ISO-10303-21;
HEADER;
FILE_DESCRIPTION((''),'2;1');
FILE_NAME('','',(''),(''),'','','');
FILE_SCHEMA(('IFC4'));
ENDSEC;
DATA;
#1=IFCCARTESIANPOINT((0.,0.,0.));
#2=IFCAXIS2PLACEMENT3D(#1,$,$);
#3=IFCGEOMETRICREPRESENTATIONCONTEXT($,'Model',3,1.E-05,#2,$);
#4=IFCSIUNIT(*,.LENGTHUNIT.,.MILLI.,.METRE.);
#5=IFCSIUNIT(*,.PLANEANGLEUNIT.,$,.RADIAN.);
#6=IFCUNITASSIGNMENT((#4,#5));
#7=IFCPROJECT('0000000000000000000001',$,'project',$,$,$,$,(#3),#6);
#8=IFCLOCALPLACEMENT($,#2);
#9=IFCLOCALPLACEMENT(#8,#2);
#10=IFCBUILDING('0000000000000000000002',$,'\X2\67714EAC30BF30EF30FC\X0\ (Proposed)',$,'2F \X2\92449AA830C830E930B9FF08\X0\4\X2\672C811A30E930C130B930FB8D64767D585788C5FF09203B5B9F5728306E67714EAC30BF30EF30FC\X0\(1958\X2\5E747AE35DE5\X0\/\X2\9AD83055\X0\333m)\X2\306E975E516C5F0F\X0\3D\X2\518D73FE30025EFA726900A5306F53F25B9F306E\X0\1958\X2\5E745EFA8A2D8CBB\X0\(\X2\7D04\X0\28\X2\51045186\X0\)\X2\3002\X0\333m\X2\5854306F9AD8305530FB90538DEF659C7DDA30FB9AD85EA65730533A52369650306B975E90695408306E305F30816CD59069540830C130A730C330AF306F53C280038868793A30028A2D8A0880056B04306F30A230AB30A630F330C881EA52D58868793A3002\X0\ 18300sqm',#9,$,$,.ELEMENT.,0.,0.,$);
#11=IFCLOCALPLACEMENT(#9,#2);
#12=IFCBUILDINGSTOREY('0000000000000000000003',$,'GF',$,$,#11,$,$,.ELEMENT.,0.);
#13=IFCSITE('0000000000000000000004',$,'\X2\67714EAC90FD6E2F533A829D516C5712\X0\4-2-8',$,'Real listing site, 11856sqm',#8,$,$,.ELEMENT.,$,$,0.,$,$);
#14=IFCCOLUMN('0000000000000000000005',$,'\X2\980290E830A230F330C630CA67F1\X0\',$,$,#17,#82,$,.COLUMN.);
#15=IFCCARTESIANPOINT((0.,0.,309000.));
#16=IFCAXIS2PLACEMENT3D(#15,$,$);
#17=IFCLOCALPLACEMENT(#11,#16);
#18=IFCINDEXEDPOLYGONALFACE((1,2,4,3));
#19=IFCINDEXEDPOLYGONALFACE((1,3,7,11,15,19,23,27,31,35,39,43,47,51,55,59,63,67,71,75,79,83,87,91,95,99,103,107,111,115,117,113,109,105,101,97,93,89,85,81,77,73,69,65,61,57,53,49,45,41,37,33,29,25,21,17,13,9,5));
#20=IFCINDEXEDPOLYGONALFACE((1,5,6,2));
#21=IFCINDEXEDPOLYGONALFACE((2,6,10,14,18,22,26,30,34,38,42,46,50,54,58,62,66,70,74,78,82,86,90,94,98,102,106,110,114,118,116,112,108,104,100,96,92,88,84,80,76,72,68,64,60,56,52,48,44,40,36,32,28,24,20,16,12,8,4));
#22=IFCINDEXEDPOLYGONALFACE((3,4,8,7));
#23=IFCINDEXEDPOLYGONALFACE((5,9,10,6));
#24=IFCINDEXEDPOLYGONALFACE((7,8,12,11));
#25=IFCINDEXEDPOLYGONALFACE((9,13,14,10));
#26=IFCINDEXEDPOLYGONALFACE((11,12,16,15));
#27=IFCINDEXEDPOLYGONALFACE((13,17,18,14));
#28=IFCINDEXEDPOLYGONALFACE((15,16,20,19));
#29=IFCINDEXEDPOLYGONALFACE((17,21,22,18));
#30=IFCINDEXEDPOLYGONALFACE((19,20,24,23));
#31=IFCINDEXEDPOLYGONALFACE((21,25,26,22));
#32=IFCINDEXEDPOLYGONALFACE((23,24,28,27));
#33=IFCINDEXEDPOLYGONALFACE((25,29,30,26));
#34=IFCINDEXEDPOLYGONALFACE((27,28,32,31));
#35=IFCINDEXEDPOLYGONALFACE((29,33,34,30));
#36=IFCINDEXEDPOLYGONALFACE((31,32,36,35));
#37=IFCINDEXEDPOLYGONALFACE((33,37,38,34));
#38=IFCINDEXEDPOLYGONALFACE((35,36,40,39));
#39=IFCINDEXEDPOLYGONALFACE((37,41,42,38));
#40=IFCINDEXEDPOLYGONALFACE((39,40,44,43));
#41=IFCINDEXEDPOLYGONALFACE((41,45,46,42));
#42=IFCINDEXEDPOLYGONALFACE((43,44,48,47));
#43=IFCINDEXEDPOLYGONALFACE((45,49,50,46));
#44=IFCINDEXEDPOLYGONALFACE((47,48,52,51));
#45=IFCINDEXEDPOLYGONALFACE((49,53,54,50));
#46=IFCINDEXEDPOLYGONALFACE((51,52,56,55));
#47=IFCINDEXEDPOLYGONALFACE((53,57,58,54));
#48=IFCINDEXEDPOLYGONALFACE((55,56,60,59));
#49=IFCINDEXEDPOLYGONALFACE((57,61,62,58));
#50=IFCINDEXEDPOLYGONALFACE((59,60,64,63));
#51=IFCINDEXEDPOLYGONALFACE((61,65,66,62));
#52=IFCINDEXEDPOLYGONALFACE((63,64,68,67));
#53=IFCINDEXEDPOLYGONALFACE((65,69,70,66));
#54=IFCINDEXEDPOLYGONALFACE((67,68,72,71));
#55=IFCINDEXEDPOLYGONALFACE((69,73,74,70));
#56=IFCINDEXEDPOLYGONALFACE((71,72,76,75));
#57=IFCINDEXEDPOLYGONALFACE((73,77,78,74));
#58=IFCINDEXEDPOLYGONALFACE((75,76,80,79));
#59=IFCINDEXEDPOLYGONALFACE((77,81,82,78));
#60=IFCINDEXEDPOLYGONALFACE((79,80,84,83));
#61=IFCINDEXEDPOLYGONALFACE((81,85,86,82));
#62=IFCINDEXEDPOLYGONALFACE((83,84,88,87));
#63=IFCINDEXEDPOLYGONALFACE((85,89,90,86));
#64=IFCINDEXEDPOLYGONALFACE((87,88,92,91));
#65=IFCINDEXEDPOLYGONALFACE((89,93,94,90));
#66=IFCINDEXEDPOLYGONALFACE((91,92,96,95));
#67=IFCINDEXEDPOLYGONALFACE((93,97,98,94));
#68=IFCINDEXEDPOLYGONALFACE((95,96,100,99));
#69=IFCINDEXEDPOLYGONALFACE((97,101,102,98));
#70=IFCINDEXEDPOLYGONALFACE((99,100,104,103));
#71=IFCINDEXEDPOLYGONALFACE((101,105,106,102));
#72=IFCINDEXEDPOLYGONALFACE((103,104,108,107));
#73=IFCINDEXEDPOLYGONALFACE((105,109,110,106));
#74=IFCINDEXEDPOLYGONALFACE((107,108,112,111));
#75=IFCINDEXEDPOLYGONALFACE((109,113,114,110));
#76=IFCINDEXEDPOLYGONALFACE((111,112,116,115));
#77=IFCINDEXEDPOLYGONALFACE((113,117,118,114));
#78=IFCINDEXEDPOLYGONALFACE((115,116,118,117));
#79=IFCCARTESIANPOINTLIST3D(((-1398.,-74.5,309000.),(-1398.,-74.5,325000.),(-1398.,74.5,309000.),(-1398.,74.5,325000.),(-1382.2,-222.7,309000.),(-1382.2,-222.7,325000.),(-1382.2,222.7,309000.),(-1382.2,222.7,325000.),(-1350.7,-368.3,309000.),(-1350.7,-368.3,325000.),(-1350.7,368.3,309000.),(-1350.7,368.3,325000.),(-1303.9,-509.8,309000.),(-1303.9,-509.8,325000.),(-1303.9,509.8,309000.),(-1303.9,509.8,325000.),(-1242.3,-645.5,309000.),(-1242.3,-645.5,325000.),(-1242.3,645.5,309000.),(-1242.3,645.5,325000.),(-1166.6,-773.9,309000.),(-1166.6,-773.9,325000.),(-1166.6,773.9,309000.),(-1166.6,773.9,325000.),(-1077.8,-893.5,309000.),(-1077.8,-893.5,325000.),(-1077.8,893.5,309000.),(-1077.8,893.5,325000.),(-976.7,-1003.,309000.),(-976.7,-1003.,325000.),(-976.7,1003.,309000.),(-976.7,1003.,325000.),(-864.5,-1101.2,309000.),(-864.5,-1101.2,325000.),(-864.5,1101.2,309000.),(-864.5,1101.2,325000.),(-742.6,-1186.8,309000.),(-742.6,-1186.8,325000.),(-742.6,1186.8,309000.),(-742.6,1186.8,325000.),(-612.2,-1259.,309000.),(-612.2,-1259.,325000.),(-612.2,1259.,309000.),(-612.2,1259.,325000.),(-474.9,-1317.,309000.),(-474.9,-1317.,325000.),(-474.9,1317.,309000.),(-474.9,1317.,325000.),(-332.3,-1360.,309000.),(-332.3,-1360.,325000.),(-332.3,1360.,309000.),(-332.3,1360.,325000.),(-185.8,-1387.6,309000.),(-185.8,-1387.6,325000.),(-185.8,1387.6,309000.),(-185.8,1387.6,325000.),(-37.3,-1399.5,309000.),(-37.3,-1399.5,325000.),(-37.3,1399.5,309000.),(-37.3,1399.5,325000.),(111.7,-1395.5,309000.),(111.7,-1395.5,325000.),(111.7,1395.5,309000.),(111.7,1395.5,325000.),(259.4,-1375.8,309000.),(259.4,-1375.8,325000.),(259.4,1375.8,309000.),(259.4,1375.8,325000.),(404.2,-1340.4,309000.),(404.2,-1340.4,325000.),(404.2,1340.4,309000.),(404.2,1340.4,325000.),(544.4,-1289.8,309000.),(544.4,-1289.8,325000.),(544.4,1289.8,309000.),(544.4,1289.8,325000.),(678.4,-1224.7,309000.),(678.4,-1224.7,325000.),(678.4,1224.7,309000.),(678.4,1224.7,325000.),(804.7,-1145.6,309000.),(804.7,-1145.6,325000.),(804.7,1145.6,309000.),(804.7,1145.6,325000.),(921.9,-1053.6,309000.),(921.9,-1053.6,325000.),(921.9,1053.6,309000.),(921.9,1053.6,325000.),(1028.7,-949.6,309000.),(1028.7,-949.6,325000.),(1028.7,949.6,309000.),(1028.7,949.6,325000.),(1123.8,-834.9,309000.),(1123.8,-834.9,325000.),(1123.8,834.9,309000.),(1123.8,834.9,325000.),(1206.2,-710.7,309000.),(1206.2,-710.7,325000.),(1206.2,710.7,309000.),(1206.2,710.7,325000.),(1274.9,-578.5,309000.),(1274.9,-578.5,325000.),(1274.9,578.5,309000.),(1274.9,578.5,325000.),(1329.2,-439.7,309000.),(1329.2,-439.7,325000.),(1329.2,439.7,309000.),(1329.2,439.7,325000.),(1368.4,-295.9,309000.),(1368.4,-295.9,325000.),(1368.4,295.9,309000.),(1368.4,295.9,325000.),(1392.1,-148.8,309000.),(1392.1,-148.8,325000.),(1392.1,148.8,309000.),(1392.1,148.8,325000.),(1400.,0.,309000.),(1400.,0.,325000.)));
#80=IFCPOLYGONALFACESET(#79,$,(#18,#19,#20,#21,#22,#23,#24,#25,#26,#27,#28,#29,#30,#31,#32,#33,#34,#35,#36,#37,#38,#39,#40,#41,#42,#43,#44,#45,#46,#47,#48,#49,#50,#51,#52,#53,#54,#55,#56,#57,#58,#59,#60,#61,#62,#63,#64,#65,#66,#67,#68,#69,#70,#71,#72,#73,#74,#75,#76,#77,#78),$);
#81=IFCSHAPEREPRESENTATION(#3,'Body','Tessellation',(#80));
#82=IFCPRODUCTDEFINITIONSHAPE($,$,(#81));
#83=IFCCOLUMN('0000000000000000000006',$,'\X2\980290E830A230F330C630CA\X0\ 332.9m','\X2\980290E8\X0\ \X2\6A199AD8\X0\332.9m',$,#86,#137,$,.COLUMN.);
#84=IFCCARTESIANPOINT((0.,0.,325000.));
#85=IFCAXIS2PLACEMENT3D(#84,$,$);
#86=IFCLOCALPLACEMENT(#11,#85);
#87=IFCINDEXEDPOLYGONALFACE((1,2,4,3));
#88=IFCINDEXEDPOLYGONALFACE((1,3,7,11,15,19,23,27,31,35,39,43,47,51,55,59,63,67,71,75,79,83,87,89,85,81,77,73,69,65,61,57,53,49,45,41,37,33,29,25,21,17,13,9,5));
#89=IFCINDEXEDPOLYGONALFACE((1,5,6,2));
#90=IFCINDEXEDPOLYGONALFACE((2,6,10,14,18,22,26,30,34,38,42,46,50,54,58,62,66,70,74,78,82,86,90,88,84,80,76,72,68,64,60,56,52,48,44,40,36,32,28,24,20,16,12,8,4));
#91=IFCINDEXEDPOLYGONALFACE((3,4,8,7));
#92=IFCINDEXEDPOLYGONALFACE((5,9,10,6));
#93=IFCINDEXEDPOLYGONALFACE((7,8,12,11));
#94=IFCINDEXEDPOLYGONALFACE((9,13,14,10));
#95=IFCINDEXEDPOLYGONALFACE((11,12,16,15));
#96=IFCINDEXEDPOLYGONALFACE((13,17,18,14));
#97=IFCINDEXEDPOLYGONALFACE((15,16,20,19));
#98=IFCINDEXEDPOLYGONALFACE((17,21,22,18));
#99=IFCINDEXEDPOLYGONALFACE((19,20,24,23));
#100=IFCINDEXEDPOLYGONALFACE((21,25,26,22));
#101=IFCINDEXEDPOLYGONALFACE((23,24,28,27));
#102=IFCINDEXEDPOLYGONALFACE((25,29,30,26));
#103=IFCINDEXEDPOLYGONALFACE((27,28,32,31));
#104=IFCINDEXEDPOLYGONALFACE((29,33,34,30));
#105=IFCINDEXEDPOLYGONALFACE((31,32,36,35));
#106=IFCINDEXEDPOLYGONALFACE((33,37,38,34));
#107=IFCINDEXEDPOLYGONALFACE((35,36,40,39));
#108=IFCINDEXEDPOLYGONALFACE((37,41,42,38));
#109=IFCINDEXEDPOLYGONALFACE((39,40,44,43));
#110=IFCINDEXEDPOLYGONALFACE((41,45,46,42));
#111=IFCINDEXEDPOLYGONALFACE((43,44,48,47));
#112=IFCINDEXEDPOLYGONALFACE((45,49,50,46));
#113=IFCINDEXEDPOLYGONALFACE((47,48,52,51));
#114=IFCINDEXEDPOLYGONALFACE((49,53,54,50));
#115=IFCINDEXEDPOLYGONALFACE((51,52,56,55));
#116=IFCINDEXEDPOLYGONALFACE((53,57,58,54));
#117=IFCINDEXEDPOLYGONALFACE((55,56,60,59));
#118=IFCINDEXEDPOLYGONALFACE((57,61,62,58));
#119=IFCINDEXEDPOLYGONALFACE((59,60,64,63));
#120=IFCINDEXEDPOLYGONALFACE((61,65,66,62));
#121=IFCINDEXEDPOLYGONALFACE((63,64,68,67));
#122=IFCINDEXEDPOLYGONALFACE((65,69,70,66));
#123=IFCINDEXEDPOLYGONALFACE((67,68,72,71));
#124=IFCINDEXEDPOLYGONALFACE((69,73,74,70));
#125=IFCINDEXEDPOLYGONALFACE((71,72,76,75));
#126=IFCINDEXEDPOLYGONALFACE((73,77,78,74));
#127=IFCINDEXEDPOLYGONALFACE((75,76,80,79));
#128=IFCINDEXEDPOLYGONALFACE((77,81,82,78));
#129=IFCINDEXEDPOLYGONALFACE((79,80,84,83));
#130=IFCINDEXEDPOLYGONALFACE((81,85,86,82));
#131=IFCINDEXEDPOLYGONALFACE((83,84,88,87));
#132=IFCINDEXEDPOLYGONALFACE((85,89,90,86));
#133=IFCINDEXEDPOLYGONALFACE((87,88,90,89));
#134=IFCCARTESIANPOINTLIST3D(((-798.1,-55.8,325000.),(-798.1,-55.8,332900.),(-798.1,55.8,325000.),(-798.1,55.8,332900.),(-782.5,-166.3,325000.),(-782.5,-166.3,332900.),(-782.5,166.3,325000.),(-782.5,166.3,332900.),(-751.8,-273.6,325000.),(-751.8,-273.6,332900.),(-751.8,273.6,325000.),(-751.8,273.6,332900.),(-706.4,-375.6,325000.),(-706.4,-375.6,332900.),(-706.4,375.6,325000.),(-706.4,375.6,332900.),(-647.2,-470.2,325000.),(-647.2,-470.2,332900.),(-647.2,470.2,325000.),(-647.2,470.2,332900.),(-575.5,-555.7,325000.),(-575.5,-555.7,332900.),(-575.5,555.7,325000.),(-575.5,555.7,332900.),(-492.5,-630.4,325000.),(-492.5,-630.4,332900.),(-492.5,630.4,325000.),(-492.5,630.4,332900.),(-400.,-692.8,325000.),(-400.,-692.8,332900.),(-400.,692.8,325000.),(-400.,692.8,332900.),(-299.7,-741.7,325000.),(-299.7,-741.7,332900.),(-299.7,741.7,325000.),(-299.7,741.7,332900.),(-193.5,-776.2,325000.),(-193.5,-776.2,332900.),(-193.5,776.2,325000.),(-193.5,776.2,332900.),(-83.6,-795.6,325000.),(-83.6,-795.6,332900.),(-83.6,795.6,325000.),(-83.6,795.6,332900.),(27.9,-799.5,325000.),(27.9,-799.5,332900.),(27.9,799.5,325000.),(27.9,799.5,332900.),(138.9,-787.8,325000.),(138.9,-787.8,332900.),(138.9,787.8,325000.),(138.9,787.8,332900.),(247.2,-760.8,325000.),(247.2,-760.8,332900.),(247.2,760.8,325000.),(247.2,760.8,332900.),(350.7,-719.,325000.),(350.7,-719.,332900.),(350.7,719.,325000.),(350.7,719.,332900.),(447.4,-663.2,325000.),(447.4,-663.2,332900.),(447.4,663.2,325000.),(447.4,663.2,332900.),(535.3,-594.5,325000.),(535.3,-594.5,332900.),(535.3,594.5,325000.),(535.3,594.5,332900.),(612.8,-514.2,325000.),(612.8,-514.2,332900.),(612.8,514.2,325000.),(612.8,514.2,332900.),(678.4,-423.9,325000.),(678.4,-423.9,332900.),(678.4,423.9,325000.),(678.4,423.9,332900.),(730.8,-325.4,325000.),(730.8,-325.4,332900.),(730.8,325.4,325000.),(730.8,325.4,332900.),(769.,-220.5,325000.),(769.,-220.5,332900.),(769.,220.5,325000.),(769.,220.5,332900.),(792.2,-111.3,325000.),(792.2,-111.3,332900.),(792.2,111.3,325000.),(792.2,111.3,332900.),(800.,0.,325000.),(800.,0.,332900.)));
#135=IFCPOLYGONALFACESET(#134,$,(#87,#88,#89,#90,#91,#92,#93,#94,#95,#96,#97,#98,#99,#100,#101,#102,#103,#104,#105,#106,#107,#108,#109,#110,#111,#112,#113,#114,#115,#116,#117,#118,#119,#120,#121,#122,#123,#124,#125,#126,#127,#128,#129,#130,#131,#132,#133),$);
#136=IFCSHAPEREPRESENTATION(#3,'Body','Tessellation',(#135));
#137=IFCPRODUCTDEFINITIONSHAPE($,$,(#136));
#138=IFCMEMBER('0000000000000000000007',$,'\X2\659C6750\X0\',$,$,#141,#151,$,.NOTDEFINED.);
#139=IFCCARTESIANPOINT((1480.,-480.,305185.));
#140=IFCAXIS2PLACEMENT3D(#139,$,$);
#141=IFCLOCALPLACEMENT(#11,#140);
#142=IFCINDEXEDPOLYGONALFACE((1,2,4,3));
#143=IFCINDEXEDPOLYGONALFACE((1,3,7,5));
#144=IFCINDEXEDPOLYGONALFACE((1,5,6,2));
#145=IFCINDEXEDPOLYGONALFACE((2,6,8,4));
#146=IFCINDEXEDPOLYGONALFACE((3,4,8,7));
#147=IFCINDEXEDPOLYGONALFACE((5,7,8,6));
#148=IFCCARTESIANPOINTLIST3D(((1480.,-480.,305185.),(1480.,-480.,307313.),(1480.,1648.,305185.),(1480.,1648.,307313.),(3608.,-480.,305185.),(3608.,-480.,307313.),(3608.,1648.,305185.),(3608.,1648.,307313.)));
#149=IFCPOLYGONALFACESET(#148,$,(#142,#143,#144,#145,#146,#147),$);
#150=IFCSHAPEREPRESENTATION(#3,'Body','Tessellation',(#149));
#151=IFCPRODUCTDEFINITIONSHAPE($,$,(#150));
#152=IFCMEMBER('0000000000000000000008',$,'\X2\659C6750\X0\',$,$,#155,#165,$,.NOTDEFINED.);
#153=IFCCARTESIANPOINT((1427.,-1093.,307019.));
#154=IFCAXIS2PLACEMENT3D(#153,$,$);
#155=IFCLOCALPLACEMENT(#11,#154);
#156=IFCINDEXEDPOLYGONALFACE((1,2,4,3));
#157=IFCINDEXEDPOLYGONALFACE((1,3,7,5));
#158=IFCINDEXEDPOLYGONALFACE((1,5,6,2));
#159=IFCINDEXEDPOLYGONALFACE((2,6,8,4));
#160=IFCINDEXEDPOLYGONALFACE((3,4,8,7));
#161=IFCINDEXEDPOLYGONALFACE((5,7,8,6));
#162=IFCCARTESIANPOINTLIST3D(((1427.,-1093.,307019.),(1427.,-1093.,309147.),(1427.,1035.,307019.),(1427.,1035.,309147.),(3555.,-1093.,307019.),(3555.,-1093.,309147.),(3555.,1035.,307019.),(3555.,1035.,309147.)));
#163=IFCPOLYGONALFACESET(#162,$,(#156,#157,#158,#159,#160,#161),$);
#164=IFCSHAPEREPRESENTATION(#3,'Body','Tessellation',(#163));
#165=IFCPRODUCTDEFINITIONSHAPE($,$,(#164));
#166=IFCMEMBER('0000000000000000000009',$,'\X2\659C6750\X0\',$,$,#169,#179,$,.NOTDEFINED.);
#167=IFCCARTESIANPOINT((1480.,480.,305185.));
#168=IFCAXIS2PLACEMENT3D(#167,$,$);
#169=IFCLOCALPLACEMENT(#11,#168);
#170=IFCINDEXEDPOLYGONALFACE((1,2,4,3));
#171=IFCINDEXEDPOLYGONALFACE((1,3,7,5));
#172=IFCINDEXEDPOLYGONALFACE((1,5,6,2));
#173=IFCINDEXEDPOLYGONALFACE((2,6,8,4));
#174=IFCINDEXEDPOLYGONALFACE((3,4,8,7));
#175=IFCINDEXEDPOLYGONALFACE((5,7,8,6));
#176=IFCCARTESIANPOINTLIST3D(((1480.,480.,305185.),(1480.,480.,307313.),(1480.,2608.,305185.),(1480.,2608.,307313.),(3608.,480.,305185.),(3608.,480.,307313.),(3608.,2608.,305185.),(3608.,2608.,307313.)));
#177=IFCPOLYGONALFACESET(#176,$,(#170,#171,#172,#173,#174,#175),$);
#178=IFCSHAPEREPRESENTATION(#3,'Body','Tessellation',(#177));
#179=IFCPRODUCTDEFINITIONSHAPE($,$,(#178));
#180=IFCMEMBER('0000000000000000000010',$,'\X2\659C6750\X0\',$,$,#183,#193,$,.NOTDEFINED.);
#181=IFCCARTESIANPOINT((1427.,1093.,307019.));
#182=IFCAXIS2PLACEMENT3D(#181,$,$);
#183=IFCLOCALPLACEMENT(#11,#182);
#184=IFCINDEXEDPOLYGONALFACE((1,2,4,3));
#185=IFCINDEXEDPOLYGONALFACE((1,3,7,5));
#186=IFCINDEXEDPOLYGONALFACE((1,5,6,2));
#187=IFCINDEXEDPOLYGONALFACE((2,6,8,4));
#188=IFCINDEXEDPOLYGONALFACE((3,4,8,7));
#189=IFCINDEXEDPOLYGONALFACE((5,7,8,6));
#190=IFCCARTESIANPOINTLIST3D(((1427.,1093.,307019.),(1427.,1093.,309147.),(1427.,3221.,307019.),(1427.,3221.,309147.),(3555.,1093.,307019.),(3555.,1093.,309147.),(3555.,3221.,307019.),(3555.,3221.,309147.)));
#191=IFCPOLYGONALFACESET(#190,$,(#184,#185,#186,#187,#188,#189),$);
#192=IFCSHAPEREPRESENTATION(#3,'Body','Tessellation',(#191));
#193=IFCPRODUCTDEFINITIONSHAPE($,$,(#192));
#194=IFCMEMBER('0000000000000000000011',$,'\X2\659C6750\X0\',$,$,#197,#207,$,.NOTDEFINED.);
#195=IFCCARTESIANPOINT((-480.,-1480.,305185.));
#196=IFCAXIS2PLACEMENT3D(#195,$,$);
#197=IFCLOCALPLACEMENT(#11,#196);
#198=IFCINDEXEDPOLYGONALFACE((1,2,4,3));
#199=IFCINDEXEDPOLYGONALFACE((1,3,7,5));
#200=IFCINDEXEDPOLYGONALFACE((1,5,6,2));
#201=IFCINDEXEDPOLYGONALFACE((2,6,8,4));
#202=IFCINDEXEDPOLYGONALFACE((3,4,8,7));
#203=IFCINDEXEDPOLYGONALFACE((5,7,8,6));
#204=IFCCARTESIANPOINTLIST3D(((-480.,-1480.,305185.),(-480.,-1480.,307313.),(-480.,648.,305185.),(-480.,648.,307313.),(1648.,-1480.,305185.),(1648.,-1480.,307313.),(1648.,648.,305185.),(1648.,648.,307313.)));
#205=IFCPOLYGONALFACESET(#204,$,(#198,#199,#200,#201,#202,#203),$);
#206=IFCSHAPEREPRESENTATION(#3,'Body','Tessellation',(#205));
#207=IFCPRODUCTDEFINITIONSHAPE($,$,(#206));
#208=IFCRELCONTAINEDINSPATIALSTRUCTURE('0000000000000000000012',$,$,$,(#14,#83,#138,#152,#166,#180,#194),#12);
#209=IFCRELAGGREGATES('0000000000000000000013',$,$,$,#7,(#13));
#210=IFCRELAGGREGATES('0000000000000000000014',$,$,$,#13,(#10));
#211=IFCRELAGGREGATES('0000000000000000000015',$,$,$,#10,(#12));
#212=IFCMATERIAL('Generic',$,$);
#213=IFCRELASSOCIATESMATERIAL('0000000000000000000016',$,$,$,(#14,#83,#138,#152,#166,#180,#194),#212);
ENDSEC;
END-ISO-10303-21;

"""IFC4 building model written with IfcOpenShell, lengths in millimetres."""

from ifc_helpers import new_model, si_unit, frame, frame_2d, origin, origin_2d, place, context, project, spatial, rectangle, circle, extrude, material, element, save


model = new_model("IFC4")

# Units and contexts
model_context = context("Model", 3, precision=1e-05, world=origin())
ifc_project = project(units=[si_unit("LENGTHUNIT", "METRE", prefix="MILLI"), si_unit("PLANEANGLEUNIT", "RADIAN")], contexts=[model_context])

# Site, building, storey
site_placement = place(None, origin())
site = spatial("IfcSite", under=ifc_project, at=site_placement, Name="東京都港区芝公園4-2-8", ObjectType="Real listing site, 11856sqm", CompositionType="ELEMENT", RefElevation=0.0)
building_placement = place(site_placement, origin())
building = spatial("IfcBuilding", under=site, at=building_placement, Name="東京タワー (Proposed)", ObjectType="2F 鉄骨トラス（4本脚ラチス・赤白塗装）※実在の東京タワー(1958年竣工/高さ333m)の非公式3D再現。建物¥は史実の1958年建設費(約28億円)。333m塔は高さ・道路斜線・高度地区制限に非適合のため法適合チェックは参考表示。設計者欄はアカウント自動表示。 18300sqm", CompositionType="ELEMENT", ElevationOfRefHeight=0.0, ElevationOfTerrain=0.0)
storey_placement = place(building_placement, origin())
storey = spatial("IfcBuildingStorey", under=building, at=storey_placement, Name="GF", CompositionType="ELEMENT", Elevation=0.0)

# Columns
ifc_material = material(Name="Generic")
column_1_placement = place(storey_placement, frame((0.0, 0.0, 309000.0)))
element("IfcColumn", 1, at=column_1_placement, inside=storey, material=ifc_material, Name="頂部アンテナ柱", PredefinedType="COLUMN", context=model_context, shape_type="SweptSolid", body=[
    extrude(circle(Radius=1400.0, at=origin_2d()), frame((0.0, 0.0, 309000.0)), (0.0, 0.0, 1.0), 16000.0),
])
column_2_placement = place(storey_placement, frame((0.0, 0.0, 325000.0)))
element("IfcColumn", 2, at=column_2_placement, inside=storey, material=ifc_material, Name="頂部アンテナ 332.9m", Description="頂部 標高332.9m", PredefinedType="COLUMN", context=model_context, shape_type="SweptSolid", body=[
    extrude(circle(Radius=800.0, at=origin_2d()), frame((0.0, 0.0, 325000.0)), (0.0, 0.0, 1.0), 7900.0),
])

# Members
member_1_placement = place(storey_placement, frame((1480.0, -480.0, 305185.0)))
element("IfcMember", 3, at=member_1_placement, inside=storey, material=ifc_material, Name="斜材", PredefinedType="NOTDEFINED", context=model_context, shape_type="SweptSolid", body=[
    extrude(rectangle(XDim=2128.0, YDim=2128.0, at=frame_2d((1064.0, 1064.0))), frame((1480.0, -480.0, 305185.0)), (0.0, 0.0, 1.0), 2128.0),
])
member_2_placement = place(storey_placement, frame((1427.0, -1093.0, 307019.0)))
element("IfcMember", 4, at=member_2_placement, inside=storey, material=ifc_material, Name="斜材", PredefinedType="NOTDEFINED", context=model_context, shape_type="SweptSolid", body=[
    extrude(rectangle(XDim=2128.0, YDim=2128.0, at=frame_2d((1064.0, 1064.0))), frame((1427.0, -1093.0, 307019.0)), (0.0, 0.0, 1.0), 2128.0),
])
member_3_placement = place(storey_placement, frame((1480.0, 480.0, 305185.0)))
element("IfcMember", 5, at=member_3_placement, inside=storey, material=ifc_material, Name="斜材", PredefinedType="NOTDEFINED", context=model_context, shape_type="SweptSolid", body=[
    extrude(rectangle(XDim=2128.0, YDim=2128.0, at=frame_2d((1064.0, 1064.0))), frame((1480.0, 480.0, 305185.0)), (0.0, 0.0, 1.0), 2128.0),
])
member_4_placement = place(storey_placement, frame((1427.0, 1093.0, 307019.0)))
element("IfcMember", 6, at=member_4_placement, inside=storey, material=ifc_material, Name="斜材", PredefinedType="NOTDEFINED", context=model_context, shape_type="SweptSolid", body=[
    extrude(rectangle(XDim=2128.0, YDim=2128.0, at=frame_2d((1064.0, 1064.0))), frame((1427.0, 1093.0, 307019.0)), (0.0, 0.0, 1.0), 2128.0),
])
member_5_placement = place(storey_placement, frame((-480.0, -1480.0, 305185.0)))
element("IfcMember", 7, at=member_5_placement, inside=storey, material=ifc_material, Name="斜材", PredefinedType="NOTDEFINED", context=model_context, shape_type="SweptSolid", body=[
    extrude(rectangle(XDim=2128.0, YDim=2128.0, at=frame_2d((1064.0, 1064.0))), frame((-480.0, -1480.0, 305185.0)), (0.0, 0.0, 1.0), 2128.0),
])

save(model, "model.ifc")
